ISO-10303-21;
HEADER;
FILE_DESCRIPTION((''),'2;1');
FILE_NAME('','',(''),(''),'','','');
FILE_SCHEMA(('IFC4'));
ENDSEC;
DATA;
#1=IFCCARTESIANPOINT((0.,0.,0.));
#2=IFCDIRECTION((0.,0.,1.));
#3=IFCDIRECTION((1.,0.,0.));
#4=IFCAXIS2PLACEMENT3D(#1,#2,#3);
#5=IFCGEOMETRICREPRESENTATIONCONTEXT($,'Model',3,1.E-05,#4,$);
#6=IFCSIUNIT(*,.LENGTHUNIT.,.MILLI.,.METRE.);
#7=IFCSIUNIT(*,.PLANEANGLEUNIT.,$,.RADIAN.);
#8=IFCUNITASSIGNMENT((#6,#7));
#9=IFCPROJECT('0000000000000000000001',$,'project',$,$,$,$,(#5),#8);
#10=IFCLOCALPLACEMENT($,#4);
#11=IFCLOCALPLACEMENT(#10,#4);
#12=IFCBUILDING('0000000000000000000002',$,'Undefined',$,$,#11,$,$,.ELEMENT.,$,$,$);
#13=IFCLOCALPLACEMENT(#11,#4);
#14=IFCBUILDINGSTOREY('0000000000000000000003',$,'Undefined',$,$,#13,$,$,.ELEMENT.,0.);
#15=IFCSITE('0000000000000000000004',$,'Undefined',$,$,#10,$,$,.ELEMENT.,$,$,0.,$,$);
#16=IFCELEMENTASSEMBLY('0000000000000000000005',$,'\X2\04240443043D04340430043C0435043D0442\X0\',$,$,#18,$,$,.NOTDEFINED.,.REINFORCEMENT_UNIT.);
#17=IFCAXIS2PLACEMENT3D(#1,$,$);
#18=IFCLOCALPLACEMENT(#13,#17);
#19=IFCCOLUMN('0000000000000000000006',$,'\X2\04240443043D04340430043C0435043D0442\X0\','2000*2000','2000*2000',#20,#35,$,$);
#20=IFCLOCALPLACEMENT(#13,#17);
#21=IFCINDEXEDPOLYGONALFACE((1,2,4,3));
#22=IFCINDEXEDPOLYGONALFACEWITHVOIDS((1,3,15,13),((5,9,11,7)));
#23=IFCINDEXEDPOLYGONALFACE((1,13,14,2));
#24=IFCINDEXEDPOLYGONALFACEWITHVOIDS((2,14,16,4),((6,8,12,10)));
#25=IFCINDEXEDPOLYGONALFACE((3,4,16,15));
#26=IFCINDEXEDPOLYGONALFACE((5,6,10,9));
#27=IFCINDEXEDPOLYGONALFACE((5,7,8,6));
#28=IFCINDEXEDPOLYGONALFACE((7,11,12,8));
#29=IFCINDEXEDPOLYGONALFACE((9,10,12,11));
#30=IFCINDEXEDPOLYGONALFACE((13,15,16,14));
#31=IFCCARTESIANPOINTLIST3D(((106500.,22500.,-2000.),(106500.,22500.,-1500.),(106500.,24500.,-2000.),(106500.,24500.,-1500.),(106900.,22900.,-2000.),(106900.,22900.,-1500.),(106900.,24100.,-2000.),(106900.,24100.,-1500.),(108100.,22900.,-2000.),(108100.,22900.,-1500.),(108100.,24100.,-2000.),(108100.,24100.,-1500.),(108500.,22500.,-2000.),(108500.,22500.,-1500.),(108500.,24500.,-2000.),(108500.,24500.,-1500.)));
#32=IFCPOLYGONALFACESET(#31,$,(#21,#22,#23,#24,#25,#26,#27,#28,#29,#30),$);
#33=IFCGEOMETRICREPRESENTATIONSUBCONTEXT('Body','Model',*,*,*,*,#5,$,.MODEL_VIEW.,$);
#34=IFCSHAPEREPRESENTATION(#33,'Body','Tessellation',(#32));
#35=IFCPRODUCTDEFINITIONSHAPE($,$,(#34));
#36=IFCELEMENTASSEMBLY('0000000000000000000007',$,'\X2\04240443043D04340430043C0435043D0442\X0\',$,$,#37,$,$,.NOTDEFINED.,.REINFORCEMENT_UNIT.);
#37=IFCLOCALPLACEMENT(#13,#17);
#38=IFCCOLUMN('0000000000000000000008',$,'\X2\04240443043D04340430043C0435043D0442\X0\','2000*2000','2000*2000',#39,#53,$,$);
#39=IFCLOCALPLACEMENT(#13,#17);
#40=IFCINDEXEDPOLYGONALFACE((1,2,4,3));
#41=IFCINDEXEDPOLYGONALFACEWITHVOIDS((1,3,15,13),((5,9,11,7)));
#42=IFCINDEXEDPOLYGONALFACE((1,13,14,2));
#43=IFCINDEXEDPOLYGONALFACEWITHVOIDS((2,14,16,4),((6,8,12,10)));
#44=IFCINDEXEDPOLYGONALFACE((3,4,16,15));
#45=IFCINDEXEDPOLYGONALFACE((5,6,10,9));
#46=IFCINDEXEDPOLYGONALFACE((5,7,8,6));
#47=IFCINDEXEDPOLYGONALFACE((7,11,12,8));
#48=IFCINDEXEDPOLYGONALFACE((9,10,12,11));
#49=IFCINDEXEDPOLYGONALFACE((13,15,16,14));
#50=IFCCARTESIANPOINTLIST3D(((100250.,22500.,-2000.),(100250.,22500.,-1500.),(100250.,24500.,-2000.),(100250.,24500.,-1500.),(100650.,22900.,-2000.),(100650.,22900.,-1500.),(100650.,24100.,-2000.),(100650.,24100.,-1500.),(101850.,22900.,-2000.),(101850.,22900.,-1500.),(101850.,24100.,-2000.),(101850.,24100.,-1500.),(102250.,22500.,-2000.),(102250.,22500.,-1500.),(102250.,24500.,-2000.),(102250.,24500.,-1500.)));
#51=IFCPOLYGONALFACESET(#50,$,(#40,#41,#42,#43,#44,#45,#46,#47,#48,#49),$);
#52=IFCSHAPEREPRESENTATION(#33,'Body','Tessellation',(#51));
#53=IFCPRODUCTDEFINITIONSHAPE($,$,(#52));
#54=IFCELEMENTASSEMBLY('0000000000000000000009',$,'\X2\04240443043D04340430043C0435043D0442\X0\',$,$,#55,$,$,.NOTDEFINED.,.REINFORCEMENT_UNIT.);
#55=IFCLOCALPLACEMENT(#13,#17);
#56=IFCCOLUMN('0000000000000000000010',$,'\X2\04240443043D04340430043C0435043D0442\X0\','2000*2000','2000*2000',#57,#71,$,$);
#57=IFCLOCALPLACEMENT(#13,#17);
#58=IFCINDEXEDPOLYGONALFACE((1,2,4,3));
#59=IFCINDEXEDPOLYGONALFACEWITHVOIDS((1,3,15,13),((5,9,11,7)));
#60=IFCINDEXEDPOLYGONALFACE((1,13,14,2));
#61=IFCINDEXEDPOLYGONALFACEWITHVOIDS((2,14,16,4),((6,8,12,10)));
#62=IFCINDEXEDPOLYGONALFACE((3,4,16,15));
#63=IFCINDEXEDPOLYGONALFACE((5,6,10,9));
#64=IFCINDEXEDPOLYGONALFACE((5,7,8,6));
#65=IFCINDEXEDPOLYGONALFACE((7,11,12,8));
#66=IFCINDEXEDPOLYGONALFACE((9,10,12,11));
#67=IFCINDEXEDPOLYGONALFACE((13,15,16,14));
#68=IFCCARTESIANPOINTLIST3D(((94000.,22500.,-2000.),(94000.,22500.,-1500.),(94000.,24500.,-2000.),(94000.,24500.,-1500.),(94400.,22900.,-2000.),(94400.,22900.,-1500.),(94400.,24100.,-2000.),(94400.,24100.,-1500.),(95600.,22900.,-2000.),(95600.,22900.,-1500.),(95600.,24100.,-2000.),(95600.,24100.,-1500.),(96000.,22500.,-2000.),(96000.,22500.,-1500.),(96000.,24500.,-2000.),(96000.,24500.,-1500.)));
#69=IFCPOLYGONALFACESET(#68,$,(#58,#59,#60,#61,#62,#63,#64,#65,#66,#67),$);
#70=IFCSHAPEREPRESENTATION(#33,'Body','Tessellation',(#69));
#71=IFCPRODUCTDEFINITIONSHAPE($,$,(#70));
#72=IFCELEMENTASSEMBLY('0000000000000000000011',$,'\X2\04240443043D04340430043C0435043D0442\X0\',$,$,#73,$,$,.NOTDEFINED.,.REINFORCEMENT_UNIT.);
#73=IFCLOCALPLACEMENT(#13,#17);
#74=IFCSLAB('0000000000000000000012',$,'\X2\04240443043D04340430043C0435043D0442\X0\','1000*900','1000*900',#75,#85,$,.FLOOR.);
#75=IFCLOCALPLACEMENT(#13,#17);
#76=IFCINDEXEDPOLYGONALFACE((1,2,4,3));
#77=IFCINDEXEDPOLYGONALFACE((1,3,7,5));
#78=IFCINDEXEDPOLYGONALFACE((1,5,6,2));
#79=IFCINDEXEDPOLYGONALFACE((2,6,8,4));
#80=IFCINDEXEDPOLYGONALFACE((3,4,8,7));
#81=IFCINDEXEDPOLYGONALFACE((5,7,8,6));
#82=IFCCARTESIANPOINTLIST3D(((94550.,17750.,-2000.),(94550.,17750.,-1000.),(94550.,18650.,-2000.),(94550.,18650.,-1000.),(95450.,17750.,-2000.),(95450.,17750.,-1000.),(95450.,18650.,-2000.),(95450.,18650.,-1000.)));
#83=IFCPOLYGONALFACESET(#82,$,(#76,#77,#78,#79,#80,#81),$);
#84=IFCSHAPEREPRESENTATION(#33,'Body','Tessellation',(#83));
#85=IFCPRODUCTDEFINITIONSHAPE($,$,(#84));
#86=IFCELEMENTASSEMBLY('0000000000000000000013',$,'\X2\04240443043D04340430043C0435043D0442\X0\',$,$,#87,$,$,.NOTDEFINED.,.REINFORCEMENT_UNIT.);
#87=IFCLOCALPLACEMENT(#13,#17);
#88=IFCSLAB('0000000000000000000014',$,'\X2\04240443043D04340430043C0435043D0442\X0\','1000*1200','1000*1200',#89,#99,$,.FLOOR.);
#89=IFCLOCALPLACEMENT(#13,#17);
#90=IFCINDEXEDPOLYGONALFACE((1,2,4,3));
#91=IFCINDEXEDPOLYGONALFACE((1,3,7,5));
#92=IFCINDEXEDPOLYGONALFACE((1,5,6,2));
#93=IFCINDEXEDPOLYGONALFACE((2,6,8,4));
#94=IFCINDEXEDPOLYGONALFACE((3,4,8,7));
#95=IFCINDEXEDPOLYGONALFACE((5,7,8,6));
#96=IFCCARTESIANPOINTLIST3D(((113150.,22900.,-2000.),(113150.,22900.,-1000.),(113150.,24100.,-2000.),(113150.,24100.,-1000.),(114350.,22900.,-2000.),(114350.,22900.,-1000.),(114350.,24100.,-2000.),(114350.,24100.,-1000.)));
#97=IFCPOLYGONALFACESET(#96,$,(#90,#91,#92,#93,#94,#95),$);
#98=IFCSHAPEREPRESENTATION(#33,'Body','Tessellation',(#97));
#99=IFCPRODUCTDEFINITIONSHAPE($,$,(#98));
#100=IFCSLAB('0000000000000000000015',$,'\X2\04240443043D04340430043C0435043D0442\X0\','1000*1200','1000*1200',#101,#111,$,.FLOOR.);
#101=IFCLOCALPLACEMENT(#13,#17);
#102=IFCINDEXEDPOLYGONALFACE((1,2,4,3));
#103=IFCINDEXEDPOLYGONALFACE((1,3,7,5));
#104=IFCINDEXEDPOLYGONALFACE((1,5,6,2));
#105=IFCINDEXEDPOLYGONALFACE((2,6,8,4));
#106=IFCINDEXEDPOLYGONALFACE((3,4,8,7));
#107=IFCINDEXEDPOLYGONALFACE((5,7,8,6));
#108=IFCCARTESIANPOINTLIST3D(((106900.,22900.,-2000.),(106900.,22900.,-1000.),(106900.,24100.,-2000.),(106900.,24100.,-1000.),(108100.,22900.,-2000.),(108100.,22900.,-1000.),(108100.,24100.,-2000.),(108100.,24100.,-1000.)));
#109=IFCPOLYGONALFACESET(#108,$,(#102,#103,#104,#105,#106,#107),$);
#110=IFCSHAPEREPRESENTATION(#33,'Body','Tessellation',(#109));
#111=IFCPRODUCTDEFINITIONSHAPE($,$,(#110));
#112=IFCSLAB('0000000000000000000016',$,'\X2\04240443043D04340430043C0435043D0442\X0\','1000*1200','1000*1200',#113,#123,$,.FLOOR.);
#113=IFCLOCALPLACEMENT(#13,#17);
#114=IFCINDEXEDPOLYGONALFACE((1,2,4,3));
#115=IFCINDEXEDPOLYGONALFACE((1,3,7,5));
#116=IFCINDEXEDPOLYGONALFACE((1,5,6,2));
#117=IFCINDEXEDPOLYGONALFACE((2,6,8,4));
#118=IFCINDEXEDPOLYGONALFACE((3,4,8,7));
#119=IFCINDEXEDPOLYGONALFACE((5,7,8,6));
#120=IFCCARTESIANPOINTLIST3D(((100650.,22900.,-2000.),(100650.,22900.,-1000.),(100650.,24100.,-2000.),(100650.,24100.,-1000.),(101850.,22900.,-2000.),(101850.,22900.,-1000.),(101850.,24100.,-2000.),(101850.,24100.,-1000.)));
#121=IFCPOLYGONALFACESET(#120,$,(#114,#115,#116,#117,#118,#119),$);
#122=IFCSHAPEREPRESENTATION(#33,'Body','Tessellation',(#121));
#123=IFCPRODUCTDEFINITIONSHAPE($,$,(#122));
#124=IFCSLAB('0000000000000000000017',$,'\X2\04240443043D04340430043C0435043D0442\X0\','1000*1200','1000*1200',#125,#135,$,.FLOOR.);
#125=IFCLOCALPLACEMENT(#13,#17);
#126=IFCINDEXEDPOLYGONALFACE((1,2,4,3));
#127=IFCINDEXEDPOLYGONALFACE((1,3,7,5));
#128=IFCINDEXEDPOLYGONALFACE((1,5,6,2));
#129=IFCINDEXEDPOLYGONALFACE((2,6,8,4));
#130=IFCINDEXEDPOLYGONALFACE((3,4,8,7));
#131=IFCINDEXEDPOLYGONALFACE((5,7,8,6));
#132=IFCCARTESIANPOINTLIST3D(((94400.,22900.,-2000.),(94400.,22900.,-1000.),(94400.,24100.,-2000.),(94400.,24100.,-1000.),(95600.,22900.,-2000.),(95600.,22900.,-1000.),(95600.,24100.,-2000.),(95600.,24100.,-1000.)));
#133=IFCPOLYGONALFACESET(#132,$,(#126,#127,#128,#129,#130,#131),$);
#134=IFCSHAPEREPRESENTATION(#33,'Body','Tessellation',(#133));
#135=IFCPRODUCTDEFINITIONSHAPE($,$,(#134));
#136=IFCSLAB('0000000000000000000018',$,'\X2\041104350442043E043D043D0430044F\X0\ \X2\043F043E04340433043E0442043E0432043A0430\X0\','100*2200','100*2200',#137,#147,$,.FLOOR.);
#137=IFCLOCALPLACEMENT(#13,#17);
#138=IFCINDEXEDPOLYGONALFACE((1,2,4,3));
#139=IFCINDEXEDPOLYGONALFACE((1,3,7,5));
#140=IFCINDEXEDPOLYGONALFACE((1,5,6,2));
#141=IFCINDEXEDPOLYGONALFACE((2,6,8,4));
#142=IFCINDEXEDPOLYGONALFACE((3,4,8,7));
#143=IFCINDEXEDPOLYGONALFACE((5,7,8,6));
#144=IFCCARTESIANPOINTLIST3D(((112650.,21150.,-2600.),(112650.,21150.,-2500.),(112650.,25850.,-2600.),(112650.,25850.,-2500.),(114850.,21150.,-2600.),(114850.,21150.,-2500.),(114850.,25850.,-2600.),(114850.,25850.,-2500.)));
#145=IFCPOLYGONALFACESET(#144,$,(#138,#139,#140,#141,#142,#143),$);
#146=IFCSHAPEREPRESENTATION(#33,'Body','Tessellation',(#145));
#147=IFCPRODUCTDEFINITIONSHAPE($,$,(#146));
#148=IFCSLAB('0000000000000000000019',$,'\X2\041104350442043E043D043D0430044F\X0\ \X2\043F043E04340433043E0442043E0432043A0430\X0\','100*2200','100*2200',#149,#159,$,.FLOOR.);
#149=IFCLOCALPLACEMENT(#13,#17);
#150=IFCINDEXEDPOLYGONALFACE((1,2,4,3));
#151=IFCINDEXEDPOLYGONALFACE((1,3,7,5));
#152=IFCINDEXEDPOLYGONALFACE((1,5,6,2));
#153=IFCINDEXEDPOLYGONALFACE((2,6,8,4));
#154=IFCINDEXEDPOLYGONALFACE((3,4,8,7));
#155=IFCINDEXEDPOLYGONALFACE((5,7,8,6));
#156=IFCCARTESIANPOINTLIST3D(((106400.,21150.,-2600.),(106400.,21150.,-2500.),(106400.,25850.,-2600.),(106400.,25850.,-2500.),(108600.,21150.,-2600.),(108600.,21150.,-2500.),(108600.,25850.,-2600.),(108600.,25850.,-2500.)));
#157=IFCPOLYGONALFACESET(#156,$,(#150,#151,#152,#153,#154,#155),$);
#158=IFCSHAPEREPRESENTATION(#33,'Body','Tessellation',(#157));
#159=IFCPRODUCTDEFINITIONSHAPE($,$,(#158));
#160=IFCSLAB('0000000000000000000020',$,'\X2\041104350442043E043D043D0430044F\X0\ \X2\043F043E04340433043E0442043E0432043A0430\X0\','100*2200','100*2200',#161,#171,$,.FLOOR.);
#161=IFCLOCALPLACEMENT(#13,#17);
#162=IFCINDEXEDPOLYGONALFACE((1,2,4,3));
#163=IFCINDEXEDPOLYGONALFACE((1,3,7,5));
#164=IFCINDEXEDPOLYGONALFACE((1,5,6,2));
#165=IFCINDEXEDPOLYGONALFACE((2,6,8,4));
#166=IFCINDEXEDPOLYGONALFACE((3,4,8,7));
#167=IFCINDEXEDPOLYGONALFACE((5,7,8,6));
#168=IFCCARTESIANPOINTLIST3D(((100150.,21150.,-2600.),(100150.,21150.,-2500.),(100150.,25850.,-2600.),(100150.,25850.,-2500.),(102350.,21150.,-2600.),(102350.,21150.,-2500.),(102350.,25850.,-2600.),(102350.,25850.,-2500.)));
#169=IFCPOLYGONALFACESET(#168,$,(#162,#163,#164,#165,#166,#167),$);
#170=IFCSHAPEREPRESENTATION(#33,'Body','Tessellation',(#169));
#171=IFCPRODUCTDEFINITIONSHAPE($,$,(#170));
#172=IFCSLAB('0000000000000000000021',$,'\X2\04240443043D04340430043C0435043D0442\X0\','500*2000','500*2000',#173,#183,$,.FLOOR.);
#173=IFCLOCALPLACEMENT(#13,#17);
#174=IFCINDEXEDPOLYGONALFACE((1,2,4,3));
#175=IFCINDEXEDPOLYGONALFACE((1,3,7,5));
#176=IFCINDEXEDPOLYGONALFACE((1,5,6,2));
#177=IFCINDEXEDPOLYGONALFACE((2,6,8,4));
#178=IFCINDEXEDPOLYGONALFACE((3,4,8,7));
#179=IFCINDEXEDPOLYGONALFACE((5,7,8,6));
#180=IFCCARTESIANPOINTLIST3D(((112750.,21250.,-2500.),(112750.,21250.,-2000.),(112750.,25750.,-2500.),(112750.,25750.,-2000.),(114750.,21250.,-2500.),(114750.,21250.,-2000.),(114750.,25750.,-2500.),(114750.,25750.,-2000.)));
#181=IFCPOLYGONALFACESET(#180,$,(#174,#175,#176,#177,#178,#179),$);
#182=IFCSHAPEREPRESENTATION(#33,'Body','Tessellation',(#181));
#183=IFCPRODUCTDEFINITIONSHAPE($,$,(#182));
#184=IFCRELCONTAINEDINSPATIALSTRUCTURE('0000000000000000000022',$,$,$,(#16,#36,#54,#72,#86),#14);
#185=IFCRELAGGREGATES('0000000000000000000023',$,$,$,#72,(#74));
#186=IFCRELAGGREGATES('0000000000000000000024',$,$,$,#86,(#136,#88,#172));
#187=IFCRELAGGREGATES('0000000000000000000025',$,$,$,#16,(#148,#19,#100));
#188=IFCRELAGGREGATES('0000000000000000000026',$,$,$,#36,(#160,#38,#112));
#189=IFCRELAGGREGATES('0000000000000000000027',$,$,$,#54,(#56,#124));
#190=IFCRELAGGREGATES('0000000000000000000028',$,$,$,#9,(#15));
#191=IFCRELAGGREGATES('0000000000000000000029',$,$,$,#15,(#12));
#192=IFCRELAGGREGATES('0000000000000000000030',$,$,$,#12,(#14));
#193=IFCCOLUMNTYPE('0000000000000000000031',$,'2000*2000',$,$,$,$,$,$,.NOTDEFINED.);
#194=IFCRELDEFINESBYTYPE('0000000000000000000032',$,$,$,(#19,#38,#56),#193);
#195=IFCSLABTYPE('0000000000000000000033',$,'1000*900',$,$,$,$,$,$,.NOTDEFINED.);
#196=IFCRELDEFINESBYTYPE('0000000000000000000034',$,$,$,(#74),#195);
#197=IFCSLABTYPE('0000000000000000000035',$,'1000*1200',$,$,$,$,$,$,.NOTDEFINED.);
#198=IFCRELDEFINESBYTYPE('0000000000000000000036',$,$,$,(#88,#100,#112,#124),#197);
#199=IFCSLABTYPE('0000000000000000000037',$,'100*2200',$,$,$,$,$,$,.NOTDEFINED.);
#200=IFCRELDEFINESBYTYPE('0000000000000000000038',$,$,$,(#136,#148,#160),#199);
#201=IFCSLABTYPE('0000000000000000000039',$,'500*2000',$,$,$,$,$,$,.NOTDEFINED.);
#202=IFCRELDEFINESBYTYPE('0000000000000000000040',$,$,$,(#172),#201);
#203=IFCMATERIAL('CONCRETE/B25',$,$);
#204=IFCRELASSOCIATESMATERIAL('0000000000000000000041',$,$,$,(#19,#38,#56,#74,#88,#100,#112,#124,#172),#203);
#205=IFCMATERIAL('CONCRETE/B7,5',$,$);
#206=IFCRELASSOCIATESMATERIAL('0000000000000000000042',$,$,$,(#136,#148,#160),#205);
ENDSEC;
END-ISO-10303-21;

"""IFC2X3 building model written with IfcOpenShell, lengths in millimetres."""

from ifc_helpers import new_model, si_unit, frame, origin_with_axes, origin_2d_with_axis, place, context, subcontext, project, spatial, polyline, rectangle, outline, extrude, boolean, material, type_object, element, aggregate, save


model = new_model("IFC2X3")

# Units and contexts
model_context = context("Model", 3, precision=1e-05, world=origin_with_axes())
body_context = subcontext(model_context, "Body", "Model", "MODEL_VIEW")
ifc_project = project(units=[si_unit("LENGTHUNIT", "METRE", prefix="MILLI"), si_unit("PLANEANGLEUNIT", "RADIAN")], contexts=[model_context])

# Site, building, storey
site_placement = place(None, origin_with_axes())
site = spatial("IfcSite", under=ifc_project, at=site_placement, Name="Undefined", CompositionType="ELEMENT", RefElevation=0.0)
building_placement = place(site_placement, origin_with_axes())
building = spatial("IfcBuilding", under=site, at=building_placement, Name="Undefined", CompositionType="ELEMENT")
storey_placement = place(building_placement, origin_with_axes())
storey = spatial("IfcBuildingStorey", under=building, at=storey_placement, Name="Undefined", CompositionType="ELEMENT", Elevation=0.0)

# Element assemblies, columns
assembly_1_placement = place(storey_placement, origin_with_axes())
assembly_1 = element("IfcElementAssembly", 1, at=assembly_1_placement, inside=storey, Name="Фундамент", AssemblyPlace="NOTDEFINED", PredefinedType="REINFORCEMENT_UNIT")
ifc_material_1 = material(Name="CONCRETE/B25")
column_type = type_object("IfcColumnType", Name="2000*2000", PredefinedType="NOTDEFINED")
column_1_placement = place(assembly_1_placement, frame((107500.0, 23500.0, -2000.0), z_axis=(0.0, 0.0, 1.0), x_axis=(0.0, -1.0, 0.0)))
column_1 = element("IfcColumn", 2, at=column_1_placement, type_object=column_type, material=ifc_material_1, Name="Фундамент", Description="2000*2000", ObjectType="2000*2000", context=body_context, shape_type="CSG", body=[
    boolean("DIFFERENCE", extrude(rectangle(XDim=2000.0, YDim=2000.0, at=origin_2d_with_axis()), frame((0.0, 0.0, 500.0), z_axis=(0.0, 0.0, -1.0), x_axis=(0.0, 1.0, 0.0)), (0.0, 0.0, 1.0), 500.0), extrude(outline(polyline([(0.0, 0.0), (1200.0, 0.0), (1200.0, 1200.0), (0.0, 1200.0), (0.0, 0.0)])), frame((-600.0, -600.0, -100.0), z_axis=(0.0, 0.0, 1.0), x_axis=(1.0, 0.0, 0.0)), (0.0, 0.0, 1.0), 700.0)),
])
assembly_2_placement = place(storey_placement, origin_with_axes())
assembly_2 = element("IfcElementAssembly", 3, at=assembly_2_placement, inside=storey, Name="Фундамент", AssemblyPlace="NOTDEFINED", PredefinedType="REINFORCEMENT_UNIT")
column_2_placement = place(assembly_2_placement, frame((101250.0, 23500.0, -2000.0), z_axis=(0.0, 0.0, 1.0), x_axis=(0.0, -1.0, 0.0)))
column_2 = element("IfcColumn", 4, at=column_2_placement, type_object=column_type, material=ifc_material_1, Name="Фундамент", Description="2000*2000", ObjectType="2000*2000", context=body_context, shape_type="CSG", body=[
    boolean("DIFFERENCE", extrude(rectangle(XDim=2000.0, YDim=2000.0, at=origin_2d_with_axis()), frame((0.0, 0.0, 500.0), z_axis=(0.0, 0.0, -1.0), x_axis=(0.0, 1.0, 0.0)), (0.0, 0.0, 1.0), 500.0), extrude(outline(polyline([(0.0, 0.0), (1200.0, 0.0), (1200.0, 1200.0), (0.0, 1200.0), (0.0, 0.0)])), frame((-600.0, -600.0, -100.0), z_axis=(0.0, 0.0, 1.0), x_axis=(1.0, 0.0, 0.0)), (0.0, 0.0, 1.0), 700.0)),
])
assembly_3_placement = place(storey_placement, origin_with_axes())
assembly_3 = element("IfcElementAssembly", 5, at=assembly_3_placement, inside=storey, Name="Фундамент", AssemblyPlace="NOTDEFINED", PredefinedType="REINFORCEMENT_UNIT")
column_3_placement = place(assembly_3_placement, frame((95000.0, 23500.0, -2000.0), z_axis=(0.0, 0.0, 1.0), x_axis=(0.0, -1.0, 0.0)))
column_3 = element("IfcColumn", 6, at=column_3_placement, type_object=column_type, material=ifc_material_1, Name="Фундамент", Description="2000*2000", ObjectType="2000*2000", context=body_context, shape_type="CSG", body=[
    boolean("DIFFERENCE", extrude(rectangle(XDim=2000.0, YDim=2000.0, at=origin_2d_with_axis()), frame((0.0, 0.0, 500.0), z_axis=(0.0, 0.0, -1.0), x_axis=(0.0, 1.0, 0.0)), (0.0, 0.0, 1.0), 500.0), extrude(outline(polyline([(0.0, 0.0), (1200.0, 0.0), (1200.0, 1200.0), (0.0, 1200.0), (0.0, 0.0)])), frame((-600.0, -600.0, -100.0), z_axis=(0.0, 0.0, 1.0), x_axis=(1.0, 0.0, 0.0)), (0.0, 0.0, 1.0), 700.0)),
])

# Element assemblies, slabs
assembly_4_placement = place(storey_placement, origin_with_axes())
assembly_4 = element("IfcElementAssembly", 7, at=assembly_4_placement, inside=storey, Name="Фундамент", AssemblyPlace="NOTDEFINED", PredefinedType="REINFORCEMENT_UNIT")
slab_type_1 = type_object("IfcSlabType", Name="1000*900", PredefinedType="NOTDEFINED")
slab_1_placement = place(assembly_4_placement, frame((94550.0, 18650.0, -1500.0), z_axis=(0.0, 0.0, 1.0), x_axis=(0.0, -1.0, 0.0)))
slab_1 = element("IfcSlab", 8, at=slab_1_placement, type_object=slab_type_1, material=ifc_material_1, Name="Фундамент", Description="1000*900", ObjectType="1000*900", PredefinedType="FLOOR", context=body_context, shape_type="SweptSolid", body=[
    extrude(outline(polyline([(0.0, 0.0), (900.0, 0.0), (900.0, 900.0), (0.0, 900.0), (0.0, 0.0)])), frame((0.0, 0.0, -500.0), z_axis=(0.0, 0.0, 1.0), x_axis=(1.0, 0.0, 0.0)), (0.0, 0.0, 1.0), 1000.0),
])
aggregate(assembly_4, [slab_1])
assembly_5_placement = place(storey_placement, origin_with_axes())
assembly_5 = element("IfcElementAssembly", 9, at=assembly_5_placement, inside=storey, Name="Фундамент", AssemblyPlace="NOTDEFINED", PredefinedType="REINFORCEMENT_UNIT")
slab_type_2 = type_object("IfcSlabType", Name="1000*1200", PredefinedType="NOTDEFINED")
slab_2_placement = place(assembly_5_placement, frame((113150.0, 24100.0, -1500.0), z_axis=(0.0, 0.0, 1.0), x_axis=(0.0, -1.0, 0.0)))
slab_2 = element("IfcSlab", 10, at=slab_2_placement, type_object=slab_type_2, material=ifc_material_1, Name="Фундамент", Description="1000*1200", ObjectType="1000*1200", PredefinedType="FLOOR", context=body_context, shape_type="SweptSolid", body=[
    extrude(outline(polyline([(0.0, 0.0), (1200.0, 0.0), (1200.0, 1200.0), (0.0, 1200.0), (0.0, 0.0)])), frame((0.0, 0.0, -500.0), z_axis=(0.0, 0.0, 1.0), x_axis=(1.0, 0.0, 0.0)), (0.0, 0.0, 1.0), 1000.0),
])

# Slabs
slab_3_placement = place(assembly_1_placement, frame((106900.0, 24100.0, -1500.0), z_axis=(0.0, 0.0, 1.0), x_axis=(0.0, -1.0, 0.0)))
slab_3 = element("IfcSlab", 11, at=slab_3_placement, type_object=slab_type_2, material=ifc_material_1, Name="Фундамент", Description="1000*1200", ObjectType="1000*1200", PredefinedType="FLOOR", context=body_context, shape_type="SweptSolid", body=[
    extrude(outline(polyline([(0.0, 0.0), (1200.0, 0.0), (1200.0, 1200.0), (0.0, 1200.0), (0.0, 0.0)])), frame((0.0, 0.0, -500.0), z_axis=(0.0, 0.0, 1.0), x_axis=(1.0, 0.0, 0.0)), (0.0, 0.0, 1.0), 1000.0),
])
slab_4_placement = place(assembly_2_placement, frame((100650.0, 24100.0, -1500.0), z_axis=(0.0, 0.0, 1.0), x_axis=(0.0, -1.0, 0.0)))
slab_4 = element("IfcSlab", 12, at=slab_4_placement, type_object=slab_type_2, material=ifc_material_1, Name="Фундамент", Description="1000*1200", ObjectType="1000*1200", PredefinedType="FLOOR", context=body_context, shape_type="SweptSolid", body=[
    extrude(outline(polyline([(0.0, 0.0), (1200.0, 0.0), (1200.0, 1200.0), (0.0, 1200.0), (0.0, 0.0)])), frame((0.0, 0.0, -500.0), z_axis=(0.0, 0.0, 1.0), x_axis=(1.0, 0.0, 0.0)), (0.0, 0.0, 1.0), 1000.0),
])
slab_5_placement = place(assembly_3_placement, frame((94400.0, 24100.0, -1500.0), z_axis=(0.0, 0.0, 1.0), x_axis=(0.0, -1.0, 0.0)))
slab_5 = element("IfcSlab", 13, at=slab_5_placement, type_object=slab_type_2, material=ifc_material_1, Name="Фундамент", Description="1000*1200", ObjectType="1000*1200", PredefinedType="FLOOR", context=body_context, shape_type="SweptSolid", body=[
    extrude(outline(polyline([(0.0, 0.0), (1200.0, 0.0), (1200.0, 1200.0), (0.0, 1200.0), (0.0, 0.0)])), frame((0.0, 0.0, -500.0), z_axis=(0.0, 0.0, 1.0), x_axis=(1.0, 0.0, 0.0)), (0.0, 0.0, 1.0), 1000.0),
])
ifc_material_2 = material(Name="CONCRETE/B7,5")
slab_type_3 = type_object("IfcSlabType", Name="100*2200", PredefinedType="NOTDEFINED")
slab_6_placement = place(assembly_5_placement, frame((112650.0, 25850.0, -2550.0), z_axis=(0.0, 0.0, 1.0), x_axis=(0.0, -1.0, 0.0)))
slab_6 = element("IfcSlab", 14, at=slab_6_placement, type_object=slab_type_3, material=ifc_material_2, Name="Бетонная подготовка", Description="100*2200", ObjectType="100*2200", PredefinedType="FLOOR", context=body_context, shape_type="SweptSolid", body=[
    extrude(outline(polyline([(0.0, 0.0), (4700.0, 0.0), (4700.0, 2200.0), (0.0, 2200.0), (0.0, 0.0)])), frame((0.0, 0.0, -50.0), z_axis=(0.0, 0.0, 1.0), x_axis=(1.0, 0.0, 0.0)), (0.0, 0.0, 1.0), 100.0),
])
slab_7_placement = place(assembly_1_placement, frame((106400.0, 25850.0, -2550.0), z_axis=(0.0, 0.0, 1.0), x_axis=(0.0, -1.0, 0.0)))
slab_7 = element("IfcSlab", 15, at=slab_7_placement, type_object=slab_type_3, material=ifc_material_2, Name="Бетонная подготовка", Description="100*2200", ObjectType="100*2200", PredefinedType="FLOOR", context=body_context, shape_type="SweptSolid", body=[
    extrude(outline(polyline([(0.0, 0.0), (4700.0, 0.0), (4700.0, 2200.0), (0.0, 2200.0), (0.0, 0.0)])), frame((0.0, 0.0, -50.0), z_axis=(0.0, 0.0, 1.0), x_axis=(1.0, 0.0, 0.0)), (0.0, 0.0, 1.0), 100.0),
])
slab_8_placement = place(assembly_2_placement, frame((100150.0, 25850.0, -2550.0), z_axis=(0.0, 0.0, 1.0), x_axis=(0.0, -1.0, 0.0)))
slab_8 = element("IfcSlab", 16, at=slab_8_placement, type_object=slab_type_3, material=ifc_material_2, Name="Бетонная подготовка", Description="100*2200", ObjectType="100*2200", PredefinedType="FLOOR", context=body_context, shape_type="SweptSolid", body=[
    extrude(outline(polyline([(0.0, 0.0), (4700.0, 0.0), (4700.0, 2200.0), (0.0, 2200.0), (0.0, 0.0)])), frame((0.0, 0.0, -50.0), z_axis=(0.0, 0.0, 1.0), x_axis=(1.0, 0.0, 0.0)), (0.0, 0.0, 1.0), 100.0),
])
slab_type_4 = type_object("IfcSlabType", Name="500*2000", PredefinedType="NOTDEFINED")
slab_9_placement = place(assembly_5_placement, frame((112750.0, 25750.0, -2250.0), z_axis=(0.0, 0.0, 1.0), x_axis=(0.0, -1.0, 0.0)))
slab_9 = element("IfcSlab", 17, at=slab_9_placement, type_object=slab_type_4, material=ifc_material_1, Name="Фундамент", Description="500*2000", ObjectType="500*2000", PredefinedType="FLOOR", context=body_context, shape_type="SweptSolid", body=[
    extrude(outline(polyline([(0.0, 0.0), (4500.0, 0.0), (4500.0, 2000.0), (0.0, 2000.0), (0.0, 0.0)])), frame((0.0, 0.0, -250.0), z_axis=(0.0, 0.0, 1.0), x_axis=(1.0, 0.0, 0.0)), (0.0, 0.0, 1.0), 500.0),
])
aggregate(assembly_5, [slab_6, slab_2, slab_9])
aggregate(assembly_1, [slab_7, column_1, slab_3])
aggregate(assembly_2, [slab_8, column_2, slab_4])
aggregate(assembly_3, [column_3, slab_5])

save(model, "model.ifc")
